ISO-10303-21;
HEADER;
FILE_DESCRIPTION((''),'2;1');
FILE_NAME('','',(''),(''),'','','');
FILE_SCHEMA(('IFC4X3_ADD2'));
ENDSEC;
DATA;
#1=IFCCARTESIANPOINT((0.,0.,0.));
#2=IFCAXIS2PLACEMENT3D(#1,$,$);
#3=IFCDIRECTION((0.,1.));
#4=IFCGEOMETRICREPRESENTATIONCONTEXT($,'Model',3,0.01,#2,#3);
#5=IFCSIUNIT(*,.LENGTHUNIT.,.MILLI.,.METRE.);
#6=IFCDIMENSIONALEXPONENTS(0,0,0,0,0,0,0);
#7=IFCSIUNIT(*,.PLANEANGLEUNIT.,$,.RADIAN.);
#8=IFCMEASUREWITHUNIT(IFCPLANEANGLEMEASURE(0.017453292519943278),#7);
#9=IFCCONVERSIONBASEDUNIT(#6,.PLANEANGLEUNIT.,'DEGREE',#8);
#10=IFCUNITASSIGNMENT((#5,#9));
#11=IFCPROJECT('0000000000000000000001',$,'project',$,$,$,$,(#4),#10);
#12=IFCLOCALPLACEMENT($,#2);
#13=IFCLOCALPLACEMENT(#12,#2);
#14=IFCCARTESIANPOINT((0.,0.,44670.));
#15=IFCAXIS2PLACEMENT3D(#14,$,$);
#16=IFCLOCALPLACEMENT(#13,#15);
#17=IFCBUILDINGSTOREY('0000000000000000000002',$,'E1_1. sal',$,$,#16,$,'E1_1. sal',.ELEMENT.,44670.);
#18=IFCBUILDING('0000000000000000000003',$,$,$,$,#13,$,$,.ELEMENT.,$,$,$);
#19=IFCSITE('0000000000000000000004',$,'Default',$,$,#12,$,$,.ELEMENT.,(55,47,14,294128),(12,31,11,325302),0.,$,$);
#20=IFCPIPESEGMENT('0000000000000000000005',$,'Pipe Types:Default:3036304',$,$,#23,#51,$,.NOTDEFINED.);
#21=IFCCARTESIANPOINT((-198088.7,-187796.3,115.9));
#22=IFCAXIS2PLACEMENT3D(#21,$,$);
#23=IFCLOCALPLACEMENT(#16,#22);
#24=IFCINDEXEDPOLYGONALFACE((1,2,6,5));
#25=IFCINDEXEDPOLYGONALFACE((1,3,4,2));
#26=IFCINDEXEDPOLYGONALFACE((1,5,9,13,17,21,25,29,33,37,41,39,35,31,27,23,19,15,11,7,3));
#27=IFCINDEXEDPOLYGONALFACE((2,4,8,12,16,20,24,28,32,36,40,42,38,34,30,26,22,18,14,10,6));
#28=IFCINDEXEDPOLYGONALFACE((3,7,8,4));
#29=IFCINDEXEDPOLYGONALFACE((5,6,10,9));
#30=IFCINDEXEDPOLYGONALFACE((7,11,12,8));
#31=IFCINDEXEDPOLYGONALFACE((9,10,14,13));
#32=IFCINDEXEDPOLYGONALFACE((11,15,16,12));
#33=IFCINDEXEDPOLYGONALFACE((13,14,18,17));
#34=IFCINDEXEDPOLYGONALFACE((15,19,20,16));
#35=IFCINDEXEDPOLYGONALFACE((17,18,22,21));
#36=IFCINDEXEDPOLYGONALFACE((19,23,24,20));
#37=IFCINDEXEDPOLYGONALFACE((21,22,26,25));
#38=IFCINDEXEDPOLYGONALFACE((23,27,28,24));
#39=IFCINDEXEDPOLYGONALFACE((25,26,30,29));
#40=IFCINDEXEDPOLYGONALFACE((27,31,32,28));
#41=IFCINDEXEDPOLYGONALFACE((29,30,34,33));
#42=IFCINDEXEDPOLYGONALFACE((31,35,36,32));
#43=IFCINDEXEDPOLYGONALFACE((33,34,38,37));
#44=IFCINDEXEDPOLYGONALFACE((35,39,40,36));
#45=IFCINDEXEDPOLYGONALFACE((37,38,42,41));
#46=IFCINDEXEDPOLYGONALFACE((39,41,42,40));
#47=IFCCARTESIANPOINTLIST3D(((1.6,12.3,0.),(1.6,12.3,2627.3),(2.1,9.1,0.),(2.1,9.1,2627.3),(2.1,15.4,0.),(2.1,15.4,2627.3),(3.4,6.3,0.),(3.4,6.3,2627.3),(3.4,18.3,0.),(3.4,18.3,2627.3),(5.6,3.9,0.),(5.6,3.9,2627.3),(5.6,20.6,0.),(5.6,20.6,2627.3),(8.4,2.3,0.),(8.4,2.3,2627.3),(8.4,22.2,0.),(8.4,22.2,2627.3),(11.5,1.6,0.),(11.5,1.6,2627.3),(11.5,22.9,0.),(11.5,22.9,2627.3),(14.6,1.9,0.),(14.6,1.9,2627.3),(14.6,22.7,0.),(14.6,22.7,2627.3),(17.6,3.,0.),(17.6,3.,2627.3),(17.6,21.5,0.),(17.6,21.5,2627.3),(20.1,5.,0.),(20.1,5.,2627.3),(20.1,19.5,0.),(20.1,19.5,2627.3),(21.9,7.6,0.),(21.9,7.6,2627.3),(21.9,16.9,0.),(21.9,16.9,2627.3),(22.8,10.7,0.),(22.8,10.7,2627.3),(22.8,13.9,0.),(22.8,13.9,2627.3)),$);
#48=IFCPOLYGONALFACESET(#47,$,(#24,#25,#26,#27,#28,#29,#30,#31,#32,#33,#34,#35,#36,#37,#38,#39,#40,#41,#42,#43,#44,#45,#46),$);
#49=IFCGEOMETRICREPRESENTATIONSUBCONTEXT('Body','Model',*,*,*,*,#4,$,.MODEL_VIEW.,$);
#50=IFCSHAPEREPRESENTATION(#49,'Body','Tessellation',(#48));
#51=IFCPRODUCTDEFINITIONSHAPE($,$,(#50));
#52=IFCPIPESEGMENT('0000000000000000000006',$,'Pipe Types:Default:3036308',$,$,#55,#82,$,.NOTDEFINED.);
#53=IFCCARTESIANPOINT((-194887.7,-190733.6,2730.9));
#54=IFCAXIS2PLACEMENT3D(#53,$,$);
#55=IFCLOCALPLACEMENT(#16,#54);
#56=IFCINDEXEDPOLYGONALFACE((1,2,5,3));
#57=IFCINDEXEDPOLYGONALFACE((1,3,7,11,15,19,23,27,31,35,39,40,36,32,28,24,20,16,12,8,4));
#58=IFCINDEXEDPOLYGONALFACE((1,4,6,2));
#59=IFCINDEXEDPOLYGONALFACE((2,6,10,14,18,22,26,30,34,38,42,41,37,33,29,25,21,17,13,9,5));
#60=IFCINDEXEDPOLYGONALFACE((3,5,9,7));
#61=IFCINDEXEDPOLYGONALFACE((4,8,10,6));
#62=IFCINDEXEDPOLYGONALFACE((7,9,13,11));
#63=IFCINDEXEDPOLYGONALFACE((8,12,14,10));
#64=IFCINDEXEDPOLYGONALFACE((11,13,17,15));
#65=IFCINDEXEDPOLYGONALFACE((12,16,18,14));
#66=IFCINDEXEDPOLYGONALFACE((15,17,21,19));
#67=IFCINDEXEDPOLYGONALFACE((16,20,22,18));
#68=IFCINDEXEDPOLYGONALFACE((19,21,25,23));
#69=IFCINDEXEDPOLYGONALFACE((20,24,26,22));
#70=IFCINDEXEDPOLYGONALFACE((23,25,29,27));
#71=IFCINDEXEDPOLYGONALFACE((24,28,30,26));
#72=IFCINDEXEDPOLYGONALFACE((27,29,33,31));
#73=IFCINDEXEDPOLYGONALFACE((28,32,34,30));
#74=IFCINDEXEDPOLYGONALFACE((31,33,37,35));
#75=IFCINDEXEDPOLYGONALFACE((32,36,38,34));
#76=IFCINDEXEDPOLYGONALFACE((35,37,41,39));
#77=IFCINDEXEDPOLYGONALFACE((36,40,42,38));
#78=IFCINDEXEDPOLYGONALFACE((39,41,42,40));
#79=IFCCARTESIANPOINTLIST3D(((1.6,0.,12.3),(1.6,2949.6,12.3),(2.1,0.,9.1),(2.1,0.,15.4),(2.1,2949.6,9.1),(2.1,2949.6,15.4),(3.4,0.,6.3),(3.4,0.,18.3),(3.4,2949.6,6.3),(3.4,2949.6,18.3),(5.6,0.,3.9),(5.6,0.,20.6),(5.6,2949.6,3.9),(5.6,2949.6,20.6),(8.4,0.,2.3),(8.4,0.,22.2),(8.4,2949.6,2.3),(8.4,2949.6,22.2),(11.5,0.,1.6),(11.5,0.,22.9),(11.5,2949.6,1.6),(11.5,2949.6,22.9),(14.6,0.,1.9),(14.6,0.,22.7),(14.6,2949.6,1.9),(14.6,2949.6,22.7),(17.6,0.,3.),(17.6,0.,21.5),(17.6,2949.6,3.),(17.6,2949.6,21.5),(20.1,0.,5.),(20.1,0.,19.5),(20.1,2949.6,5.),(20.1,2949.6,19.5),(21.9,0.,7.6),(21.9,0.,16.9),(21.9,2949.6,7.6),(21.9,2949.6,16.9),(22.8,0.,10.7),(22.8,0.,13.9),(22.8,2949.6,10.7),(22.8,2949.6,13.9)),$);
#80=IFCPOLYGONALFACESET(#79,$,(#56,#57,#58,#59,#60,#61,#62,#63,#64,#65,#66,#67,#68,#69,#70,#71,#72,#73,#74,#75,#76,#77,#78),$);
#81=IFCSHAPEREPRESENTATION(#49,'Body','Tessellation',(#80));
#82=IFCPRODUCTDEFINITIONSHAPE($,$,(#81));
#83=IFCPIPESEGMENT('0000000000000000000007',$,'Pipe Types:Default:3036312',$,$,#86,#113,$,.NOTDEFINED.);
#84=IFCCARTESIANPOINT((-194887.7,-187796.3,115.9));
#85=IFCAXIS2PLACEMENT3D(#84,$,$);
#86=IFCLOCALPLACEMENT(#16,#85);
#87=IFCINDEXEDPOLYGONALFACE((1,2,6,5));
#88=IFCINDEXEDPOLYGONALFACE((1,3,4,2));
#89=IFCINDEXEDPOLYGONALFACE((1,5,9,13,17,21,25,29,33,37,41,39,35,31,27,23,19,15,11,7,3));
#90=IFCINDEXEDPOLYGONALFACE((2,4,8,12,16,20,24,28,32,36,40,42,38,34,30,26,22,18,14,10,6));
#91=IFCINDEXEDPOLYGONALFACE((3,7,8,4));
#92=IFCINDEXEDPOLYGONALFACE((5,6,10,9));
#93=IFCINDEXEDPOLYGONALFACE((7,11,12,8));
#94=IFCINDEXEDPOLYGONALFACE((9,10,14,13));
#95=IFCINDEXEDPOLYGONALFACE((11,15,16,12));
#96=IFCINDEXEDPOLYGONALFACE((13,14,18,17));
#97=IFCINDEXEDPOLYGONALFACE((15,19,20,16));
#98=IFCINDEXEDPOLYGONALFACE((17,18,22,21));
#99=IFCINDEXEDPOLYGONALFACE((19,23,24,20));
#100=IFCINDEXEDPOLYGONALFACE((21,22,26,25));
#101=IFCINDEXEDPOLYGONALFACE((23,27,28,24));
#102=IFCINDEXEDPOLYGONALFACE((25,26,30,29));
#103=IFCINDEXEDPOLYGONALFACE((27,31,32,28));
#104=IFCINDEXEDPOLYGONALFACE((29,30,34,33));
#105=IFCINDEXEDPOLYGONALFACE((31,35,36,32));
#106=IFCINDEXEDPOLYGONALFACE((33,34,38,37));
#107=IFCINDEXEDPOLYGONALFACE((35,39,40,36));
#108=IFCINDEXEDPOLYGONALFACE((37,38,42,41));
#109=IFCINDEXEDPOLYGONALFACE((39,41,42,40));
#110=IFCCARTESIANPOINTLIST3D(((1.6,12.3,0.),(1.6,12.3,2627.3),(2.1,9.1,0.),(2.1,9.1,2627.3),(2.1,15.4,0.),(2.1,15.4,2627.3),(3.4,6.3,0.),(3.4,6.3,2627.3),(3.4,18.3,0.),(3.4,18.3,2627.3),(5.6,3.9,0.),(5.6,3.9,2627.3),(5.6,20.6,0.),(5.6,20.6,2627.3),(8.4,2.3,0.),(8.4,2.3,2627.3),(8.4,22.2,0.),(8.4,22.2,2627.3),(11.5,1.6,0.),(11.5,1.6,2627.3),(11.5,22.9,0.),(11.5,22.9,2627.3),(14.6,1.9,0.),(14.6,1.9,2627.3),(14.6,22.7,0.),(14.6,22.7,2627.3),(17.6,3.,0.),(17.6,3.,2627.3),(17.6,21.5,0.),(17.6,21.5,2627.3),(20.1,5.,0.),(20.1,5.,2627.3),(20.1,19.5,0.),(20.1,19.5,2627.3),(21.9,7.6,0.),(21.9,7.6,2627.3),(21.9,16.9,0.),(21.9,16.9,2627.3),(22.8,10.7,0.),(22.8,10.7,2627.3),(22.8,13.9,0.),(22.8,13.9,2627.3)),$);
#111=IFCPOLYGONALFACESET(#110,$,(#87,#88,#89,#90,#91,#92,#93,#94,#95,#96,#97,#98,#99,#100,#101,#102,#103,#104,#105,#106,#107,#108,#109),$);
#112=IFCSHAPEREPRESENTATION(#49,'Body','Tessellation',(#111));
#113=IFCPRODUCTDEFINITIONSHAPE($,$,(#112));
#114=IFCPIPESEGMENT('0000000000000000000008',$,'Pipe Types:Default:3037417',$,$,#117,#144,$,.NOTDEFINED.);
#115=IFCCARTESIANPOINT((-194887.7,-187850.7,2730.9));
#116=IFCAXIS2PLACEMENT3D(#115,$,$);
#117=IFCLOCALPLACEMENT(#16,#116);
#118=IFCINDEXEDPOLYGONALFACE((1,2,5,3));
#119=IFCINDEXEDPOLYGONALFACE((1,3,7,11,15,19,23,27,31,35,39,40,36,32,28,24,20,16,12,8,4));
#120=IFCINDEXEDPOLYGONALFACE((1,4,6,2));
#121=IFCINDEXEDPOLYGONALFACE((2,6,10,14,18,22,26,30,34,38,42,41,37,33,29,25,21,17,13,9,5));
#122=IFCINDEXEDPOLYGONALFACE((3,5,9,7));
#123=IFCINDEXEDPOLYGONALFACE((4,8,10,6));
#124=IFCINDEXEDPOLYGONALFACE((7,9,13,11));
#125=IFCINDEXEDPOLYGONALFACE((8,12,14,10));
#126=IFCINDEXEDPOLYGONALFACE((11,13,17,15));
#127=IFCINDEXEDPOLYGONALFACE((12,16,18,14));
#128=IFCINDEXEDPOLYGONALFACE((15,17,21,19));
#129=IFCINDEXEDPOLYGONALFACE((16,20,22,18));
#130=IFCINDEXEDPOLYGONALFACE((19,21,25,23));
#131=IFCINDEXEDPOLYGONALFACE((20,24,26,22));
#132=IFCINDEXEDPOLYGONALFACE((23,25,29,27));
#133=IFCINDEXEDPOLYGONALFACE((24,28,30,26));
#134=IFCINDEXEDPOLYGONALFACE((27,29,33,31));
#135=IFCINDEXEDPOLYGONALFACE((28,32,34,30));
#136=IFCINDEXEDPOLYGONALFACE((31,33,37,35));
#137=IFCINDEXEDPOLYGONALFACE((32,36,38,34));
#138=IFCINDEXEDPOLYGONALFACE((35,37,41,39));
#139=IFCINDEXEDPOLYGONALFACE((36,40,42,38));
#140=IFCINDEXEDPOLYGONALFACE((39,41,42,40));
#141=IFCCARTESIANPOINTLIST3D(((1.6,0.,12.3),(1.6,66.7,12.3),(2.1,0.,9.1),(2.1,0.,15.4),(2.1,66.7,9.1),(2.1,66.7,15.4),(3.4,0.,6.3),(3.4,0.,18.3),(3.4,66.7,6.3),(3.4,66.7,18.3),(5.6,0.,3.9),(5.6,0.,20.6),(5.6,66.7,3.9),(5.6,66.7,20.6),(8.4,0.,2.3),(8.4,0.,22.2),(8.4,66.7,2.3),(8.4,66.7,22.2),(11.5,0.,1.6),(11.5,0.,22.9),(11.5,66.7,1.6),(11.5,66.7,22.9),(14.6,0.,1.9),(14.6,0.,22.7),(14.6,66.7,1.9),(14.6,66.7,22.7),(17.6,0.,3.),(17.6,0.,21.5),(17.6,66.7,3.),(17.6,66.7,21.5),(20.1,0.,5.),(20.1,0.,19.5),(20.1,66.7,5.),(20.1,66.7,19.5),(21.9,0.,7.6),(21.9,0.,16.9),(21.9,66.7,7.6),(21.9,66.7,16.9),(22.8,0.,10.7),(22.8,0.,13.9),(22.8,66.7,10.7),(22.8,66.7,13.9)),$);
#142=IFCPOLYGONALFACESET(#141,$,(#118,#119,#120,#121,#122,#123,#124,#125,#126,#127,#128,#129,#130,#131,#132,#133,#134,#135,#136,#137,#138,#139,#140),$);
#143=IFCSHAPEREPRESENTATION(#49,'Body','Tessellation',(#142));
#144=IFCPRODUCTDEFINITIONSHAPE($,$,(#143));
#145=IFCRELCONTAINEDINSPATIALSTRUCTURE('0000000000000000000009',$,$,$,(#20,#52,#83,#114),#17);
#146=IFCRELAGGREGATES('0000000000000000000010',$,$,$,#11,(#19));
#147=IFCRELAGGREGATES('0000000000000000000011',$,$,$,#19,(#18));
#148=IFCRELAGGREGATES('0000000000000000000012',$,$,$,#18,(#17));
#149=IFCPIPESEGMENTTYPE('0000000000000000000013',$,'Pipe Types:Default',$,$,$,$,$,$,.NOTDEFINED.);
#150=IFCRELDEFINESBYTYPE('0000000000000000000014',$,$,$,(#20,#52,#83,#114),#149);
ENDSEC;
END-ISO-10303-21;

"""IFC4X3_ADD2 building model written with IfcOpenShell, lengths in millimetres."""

from ifc_helpers import new_model, entity, si_unit, converted_unit, direction, frame, origin, origin_2d_with_axis, place, context, subcontext, project, spatial, circle, extrude, type_object, element, save


model = new_model("IFC4X3_ADD2")

# Units and contexts
model_context = context("Model", 3, precision=0.01, world=origin(), true_north=direction((0.0, 1.0)))
body_context = subcontext(model_context, "Body", "Model", "MODEL_VIEW")
ifc_project = project(units=[si_unit("LENGTHUNIT", "METRE", prefix="MILLI"), converted_unit("PLANEANGLEUNIT", "DEGREE", entity("IfcPlaneAngleMeasure", 0.017453292519943278), si_unit("PLANEANGLEUNIT", "RADIAN"), dimensions=[0, 0, 0, 0, 0, 0, 0])], contexts=[model_context])

# Site, building, storey
site_placement = place(None, origin())
site = spatial("IfcSite", under=ifc_project, at=site_placement, Name="Default", CompositionType="ELEMENT", RefLatitude=(55, 47, 14, 294128), RefLongitude=(12, 31, 11, 325302), RefElevation=0.0)
building_placement = place(site_placement, origin())
building = spatial("IfcBuilding", under=site, at=building_placement, CompositionType="ELEMENT")
storey_placement = place(building_placement, frame((0.0, 0.0, 44670.0)))
storey = spatial("IfcBuildingStorey", under=building, at=storey_placement, Name="E1_1. sal", LongName="E1_1. sal", CompositionType="ELEMENT", Elevation=44670.0)

# Pipe segments
pipe_segment_type = type_object("IfcPipeSegmentType", Name="Pipe Types:Default", PredefinedType="NOTDEFINED")
pipe_segment_1_placement = place(storey_placement, frame((-198088.7, -187796.3, 115.9)))
element("IfcPipeSegment", 1, at=pipe_segment_1_placement, inside=storey, type_object=pipe_segment_type, Name="Pipe Types:Default:3036304", PredefinedType="NOTDEFINED", context=body_context, shape_type="SweptSolid", body=[
    extrude(circle(Radius=10.7, at=origin_2d_with_axis()), frame((12.3, 12.3, 0.0), z_axis=(0.0, 0.0, 1.0), x_axis=(-1.0, 0.0, 0.0)), (0.0, 0.0, 1.0), 2627.3),
])
pipe_segment_2_placement = place(storey_placement, frame((-194887.7, -190733.6, 2730.9)))
element("IfcPipeSegment", 2, at=pipe_segment_2_placement, inside=storey, type_object=pipe_segment_type, Name="Pipe Types:Default:3036308", PredefinedType="NOTDEFINED", context=body_context, shape_type="SweptSolid", body=[
    extrude(circle(Radius=10.7, at=origin_2d_with_axis()), frame((12.3, 0.0, 12.3), z_axis=(0.0, 1.0, 0.0), x_axis=(-1.0, 0.0, 0.0)), (0.0, 0.0, 1.0), 2949.6),
])
for number, where, name in (
    (3, (-194887.7, -187796.3, 115.9), "Pipe Types:Default:3036312"),
):
    element("IfcPipeSegment", number, at=place(storey_placement, frame(where)), inside=storey, type_object=pipe_segment_type, Name=name, PredefinedType="NOTDEFINED", context=body_context, shape_type="SweptSolid", body=[
        extrude(circle(Radius=10.7, at=origin_2d_with_axis()), frame((12.3, 12.3, 0.0), z_axis=(0.0, 0.0, 1.0), x_axis=(-1.0, 0.0, 0.0)), (0.0, 0.0, 1.0), 2627.3),
    ])
pipe_segment_3_placement = place(storey_placement, frame((-194887.7, -187850.7, 2730.9)))
element("IfcPipeSegment", 4, at=pipe_segment_3_placement, inside=storey, type_object=pipe_segment_type, Name="Pipe Types:Default:3037417", PredefinedType="NOTDEFINED", context=body_context, shape_type="SweptSolid", body=[
    extrude(circle(Radius=10.7, at=origin_2d_with_axis()), frame((12.3, 0.0, 12.3), z_axis=(0.0, 1.0, 0.0), x_axis=(-1.0, 0.0, 0.0)), (0.0, 0.0, 1.0), 66.7),
])

save(model, "model.ifc")
